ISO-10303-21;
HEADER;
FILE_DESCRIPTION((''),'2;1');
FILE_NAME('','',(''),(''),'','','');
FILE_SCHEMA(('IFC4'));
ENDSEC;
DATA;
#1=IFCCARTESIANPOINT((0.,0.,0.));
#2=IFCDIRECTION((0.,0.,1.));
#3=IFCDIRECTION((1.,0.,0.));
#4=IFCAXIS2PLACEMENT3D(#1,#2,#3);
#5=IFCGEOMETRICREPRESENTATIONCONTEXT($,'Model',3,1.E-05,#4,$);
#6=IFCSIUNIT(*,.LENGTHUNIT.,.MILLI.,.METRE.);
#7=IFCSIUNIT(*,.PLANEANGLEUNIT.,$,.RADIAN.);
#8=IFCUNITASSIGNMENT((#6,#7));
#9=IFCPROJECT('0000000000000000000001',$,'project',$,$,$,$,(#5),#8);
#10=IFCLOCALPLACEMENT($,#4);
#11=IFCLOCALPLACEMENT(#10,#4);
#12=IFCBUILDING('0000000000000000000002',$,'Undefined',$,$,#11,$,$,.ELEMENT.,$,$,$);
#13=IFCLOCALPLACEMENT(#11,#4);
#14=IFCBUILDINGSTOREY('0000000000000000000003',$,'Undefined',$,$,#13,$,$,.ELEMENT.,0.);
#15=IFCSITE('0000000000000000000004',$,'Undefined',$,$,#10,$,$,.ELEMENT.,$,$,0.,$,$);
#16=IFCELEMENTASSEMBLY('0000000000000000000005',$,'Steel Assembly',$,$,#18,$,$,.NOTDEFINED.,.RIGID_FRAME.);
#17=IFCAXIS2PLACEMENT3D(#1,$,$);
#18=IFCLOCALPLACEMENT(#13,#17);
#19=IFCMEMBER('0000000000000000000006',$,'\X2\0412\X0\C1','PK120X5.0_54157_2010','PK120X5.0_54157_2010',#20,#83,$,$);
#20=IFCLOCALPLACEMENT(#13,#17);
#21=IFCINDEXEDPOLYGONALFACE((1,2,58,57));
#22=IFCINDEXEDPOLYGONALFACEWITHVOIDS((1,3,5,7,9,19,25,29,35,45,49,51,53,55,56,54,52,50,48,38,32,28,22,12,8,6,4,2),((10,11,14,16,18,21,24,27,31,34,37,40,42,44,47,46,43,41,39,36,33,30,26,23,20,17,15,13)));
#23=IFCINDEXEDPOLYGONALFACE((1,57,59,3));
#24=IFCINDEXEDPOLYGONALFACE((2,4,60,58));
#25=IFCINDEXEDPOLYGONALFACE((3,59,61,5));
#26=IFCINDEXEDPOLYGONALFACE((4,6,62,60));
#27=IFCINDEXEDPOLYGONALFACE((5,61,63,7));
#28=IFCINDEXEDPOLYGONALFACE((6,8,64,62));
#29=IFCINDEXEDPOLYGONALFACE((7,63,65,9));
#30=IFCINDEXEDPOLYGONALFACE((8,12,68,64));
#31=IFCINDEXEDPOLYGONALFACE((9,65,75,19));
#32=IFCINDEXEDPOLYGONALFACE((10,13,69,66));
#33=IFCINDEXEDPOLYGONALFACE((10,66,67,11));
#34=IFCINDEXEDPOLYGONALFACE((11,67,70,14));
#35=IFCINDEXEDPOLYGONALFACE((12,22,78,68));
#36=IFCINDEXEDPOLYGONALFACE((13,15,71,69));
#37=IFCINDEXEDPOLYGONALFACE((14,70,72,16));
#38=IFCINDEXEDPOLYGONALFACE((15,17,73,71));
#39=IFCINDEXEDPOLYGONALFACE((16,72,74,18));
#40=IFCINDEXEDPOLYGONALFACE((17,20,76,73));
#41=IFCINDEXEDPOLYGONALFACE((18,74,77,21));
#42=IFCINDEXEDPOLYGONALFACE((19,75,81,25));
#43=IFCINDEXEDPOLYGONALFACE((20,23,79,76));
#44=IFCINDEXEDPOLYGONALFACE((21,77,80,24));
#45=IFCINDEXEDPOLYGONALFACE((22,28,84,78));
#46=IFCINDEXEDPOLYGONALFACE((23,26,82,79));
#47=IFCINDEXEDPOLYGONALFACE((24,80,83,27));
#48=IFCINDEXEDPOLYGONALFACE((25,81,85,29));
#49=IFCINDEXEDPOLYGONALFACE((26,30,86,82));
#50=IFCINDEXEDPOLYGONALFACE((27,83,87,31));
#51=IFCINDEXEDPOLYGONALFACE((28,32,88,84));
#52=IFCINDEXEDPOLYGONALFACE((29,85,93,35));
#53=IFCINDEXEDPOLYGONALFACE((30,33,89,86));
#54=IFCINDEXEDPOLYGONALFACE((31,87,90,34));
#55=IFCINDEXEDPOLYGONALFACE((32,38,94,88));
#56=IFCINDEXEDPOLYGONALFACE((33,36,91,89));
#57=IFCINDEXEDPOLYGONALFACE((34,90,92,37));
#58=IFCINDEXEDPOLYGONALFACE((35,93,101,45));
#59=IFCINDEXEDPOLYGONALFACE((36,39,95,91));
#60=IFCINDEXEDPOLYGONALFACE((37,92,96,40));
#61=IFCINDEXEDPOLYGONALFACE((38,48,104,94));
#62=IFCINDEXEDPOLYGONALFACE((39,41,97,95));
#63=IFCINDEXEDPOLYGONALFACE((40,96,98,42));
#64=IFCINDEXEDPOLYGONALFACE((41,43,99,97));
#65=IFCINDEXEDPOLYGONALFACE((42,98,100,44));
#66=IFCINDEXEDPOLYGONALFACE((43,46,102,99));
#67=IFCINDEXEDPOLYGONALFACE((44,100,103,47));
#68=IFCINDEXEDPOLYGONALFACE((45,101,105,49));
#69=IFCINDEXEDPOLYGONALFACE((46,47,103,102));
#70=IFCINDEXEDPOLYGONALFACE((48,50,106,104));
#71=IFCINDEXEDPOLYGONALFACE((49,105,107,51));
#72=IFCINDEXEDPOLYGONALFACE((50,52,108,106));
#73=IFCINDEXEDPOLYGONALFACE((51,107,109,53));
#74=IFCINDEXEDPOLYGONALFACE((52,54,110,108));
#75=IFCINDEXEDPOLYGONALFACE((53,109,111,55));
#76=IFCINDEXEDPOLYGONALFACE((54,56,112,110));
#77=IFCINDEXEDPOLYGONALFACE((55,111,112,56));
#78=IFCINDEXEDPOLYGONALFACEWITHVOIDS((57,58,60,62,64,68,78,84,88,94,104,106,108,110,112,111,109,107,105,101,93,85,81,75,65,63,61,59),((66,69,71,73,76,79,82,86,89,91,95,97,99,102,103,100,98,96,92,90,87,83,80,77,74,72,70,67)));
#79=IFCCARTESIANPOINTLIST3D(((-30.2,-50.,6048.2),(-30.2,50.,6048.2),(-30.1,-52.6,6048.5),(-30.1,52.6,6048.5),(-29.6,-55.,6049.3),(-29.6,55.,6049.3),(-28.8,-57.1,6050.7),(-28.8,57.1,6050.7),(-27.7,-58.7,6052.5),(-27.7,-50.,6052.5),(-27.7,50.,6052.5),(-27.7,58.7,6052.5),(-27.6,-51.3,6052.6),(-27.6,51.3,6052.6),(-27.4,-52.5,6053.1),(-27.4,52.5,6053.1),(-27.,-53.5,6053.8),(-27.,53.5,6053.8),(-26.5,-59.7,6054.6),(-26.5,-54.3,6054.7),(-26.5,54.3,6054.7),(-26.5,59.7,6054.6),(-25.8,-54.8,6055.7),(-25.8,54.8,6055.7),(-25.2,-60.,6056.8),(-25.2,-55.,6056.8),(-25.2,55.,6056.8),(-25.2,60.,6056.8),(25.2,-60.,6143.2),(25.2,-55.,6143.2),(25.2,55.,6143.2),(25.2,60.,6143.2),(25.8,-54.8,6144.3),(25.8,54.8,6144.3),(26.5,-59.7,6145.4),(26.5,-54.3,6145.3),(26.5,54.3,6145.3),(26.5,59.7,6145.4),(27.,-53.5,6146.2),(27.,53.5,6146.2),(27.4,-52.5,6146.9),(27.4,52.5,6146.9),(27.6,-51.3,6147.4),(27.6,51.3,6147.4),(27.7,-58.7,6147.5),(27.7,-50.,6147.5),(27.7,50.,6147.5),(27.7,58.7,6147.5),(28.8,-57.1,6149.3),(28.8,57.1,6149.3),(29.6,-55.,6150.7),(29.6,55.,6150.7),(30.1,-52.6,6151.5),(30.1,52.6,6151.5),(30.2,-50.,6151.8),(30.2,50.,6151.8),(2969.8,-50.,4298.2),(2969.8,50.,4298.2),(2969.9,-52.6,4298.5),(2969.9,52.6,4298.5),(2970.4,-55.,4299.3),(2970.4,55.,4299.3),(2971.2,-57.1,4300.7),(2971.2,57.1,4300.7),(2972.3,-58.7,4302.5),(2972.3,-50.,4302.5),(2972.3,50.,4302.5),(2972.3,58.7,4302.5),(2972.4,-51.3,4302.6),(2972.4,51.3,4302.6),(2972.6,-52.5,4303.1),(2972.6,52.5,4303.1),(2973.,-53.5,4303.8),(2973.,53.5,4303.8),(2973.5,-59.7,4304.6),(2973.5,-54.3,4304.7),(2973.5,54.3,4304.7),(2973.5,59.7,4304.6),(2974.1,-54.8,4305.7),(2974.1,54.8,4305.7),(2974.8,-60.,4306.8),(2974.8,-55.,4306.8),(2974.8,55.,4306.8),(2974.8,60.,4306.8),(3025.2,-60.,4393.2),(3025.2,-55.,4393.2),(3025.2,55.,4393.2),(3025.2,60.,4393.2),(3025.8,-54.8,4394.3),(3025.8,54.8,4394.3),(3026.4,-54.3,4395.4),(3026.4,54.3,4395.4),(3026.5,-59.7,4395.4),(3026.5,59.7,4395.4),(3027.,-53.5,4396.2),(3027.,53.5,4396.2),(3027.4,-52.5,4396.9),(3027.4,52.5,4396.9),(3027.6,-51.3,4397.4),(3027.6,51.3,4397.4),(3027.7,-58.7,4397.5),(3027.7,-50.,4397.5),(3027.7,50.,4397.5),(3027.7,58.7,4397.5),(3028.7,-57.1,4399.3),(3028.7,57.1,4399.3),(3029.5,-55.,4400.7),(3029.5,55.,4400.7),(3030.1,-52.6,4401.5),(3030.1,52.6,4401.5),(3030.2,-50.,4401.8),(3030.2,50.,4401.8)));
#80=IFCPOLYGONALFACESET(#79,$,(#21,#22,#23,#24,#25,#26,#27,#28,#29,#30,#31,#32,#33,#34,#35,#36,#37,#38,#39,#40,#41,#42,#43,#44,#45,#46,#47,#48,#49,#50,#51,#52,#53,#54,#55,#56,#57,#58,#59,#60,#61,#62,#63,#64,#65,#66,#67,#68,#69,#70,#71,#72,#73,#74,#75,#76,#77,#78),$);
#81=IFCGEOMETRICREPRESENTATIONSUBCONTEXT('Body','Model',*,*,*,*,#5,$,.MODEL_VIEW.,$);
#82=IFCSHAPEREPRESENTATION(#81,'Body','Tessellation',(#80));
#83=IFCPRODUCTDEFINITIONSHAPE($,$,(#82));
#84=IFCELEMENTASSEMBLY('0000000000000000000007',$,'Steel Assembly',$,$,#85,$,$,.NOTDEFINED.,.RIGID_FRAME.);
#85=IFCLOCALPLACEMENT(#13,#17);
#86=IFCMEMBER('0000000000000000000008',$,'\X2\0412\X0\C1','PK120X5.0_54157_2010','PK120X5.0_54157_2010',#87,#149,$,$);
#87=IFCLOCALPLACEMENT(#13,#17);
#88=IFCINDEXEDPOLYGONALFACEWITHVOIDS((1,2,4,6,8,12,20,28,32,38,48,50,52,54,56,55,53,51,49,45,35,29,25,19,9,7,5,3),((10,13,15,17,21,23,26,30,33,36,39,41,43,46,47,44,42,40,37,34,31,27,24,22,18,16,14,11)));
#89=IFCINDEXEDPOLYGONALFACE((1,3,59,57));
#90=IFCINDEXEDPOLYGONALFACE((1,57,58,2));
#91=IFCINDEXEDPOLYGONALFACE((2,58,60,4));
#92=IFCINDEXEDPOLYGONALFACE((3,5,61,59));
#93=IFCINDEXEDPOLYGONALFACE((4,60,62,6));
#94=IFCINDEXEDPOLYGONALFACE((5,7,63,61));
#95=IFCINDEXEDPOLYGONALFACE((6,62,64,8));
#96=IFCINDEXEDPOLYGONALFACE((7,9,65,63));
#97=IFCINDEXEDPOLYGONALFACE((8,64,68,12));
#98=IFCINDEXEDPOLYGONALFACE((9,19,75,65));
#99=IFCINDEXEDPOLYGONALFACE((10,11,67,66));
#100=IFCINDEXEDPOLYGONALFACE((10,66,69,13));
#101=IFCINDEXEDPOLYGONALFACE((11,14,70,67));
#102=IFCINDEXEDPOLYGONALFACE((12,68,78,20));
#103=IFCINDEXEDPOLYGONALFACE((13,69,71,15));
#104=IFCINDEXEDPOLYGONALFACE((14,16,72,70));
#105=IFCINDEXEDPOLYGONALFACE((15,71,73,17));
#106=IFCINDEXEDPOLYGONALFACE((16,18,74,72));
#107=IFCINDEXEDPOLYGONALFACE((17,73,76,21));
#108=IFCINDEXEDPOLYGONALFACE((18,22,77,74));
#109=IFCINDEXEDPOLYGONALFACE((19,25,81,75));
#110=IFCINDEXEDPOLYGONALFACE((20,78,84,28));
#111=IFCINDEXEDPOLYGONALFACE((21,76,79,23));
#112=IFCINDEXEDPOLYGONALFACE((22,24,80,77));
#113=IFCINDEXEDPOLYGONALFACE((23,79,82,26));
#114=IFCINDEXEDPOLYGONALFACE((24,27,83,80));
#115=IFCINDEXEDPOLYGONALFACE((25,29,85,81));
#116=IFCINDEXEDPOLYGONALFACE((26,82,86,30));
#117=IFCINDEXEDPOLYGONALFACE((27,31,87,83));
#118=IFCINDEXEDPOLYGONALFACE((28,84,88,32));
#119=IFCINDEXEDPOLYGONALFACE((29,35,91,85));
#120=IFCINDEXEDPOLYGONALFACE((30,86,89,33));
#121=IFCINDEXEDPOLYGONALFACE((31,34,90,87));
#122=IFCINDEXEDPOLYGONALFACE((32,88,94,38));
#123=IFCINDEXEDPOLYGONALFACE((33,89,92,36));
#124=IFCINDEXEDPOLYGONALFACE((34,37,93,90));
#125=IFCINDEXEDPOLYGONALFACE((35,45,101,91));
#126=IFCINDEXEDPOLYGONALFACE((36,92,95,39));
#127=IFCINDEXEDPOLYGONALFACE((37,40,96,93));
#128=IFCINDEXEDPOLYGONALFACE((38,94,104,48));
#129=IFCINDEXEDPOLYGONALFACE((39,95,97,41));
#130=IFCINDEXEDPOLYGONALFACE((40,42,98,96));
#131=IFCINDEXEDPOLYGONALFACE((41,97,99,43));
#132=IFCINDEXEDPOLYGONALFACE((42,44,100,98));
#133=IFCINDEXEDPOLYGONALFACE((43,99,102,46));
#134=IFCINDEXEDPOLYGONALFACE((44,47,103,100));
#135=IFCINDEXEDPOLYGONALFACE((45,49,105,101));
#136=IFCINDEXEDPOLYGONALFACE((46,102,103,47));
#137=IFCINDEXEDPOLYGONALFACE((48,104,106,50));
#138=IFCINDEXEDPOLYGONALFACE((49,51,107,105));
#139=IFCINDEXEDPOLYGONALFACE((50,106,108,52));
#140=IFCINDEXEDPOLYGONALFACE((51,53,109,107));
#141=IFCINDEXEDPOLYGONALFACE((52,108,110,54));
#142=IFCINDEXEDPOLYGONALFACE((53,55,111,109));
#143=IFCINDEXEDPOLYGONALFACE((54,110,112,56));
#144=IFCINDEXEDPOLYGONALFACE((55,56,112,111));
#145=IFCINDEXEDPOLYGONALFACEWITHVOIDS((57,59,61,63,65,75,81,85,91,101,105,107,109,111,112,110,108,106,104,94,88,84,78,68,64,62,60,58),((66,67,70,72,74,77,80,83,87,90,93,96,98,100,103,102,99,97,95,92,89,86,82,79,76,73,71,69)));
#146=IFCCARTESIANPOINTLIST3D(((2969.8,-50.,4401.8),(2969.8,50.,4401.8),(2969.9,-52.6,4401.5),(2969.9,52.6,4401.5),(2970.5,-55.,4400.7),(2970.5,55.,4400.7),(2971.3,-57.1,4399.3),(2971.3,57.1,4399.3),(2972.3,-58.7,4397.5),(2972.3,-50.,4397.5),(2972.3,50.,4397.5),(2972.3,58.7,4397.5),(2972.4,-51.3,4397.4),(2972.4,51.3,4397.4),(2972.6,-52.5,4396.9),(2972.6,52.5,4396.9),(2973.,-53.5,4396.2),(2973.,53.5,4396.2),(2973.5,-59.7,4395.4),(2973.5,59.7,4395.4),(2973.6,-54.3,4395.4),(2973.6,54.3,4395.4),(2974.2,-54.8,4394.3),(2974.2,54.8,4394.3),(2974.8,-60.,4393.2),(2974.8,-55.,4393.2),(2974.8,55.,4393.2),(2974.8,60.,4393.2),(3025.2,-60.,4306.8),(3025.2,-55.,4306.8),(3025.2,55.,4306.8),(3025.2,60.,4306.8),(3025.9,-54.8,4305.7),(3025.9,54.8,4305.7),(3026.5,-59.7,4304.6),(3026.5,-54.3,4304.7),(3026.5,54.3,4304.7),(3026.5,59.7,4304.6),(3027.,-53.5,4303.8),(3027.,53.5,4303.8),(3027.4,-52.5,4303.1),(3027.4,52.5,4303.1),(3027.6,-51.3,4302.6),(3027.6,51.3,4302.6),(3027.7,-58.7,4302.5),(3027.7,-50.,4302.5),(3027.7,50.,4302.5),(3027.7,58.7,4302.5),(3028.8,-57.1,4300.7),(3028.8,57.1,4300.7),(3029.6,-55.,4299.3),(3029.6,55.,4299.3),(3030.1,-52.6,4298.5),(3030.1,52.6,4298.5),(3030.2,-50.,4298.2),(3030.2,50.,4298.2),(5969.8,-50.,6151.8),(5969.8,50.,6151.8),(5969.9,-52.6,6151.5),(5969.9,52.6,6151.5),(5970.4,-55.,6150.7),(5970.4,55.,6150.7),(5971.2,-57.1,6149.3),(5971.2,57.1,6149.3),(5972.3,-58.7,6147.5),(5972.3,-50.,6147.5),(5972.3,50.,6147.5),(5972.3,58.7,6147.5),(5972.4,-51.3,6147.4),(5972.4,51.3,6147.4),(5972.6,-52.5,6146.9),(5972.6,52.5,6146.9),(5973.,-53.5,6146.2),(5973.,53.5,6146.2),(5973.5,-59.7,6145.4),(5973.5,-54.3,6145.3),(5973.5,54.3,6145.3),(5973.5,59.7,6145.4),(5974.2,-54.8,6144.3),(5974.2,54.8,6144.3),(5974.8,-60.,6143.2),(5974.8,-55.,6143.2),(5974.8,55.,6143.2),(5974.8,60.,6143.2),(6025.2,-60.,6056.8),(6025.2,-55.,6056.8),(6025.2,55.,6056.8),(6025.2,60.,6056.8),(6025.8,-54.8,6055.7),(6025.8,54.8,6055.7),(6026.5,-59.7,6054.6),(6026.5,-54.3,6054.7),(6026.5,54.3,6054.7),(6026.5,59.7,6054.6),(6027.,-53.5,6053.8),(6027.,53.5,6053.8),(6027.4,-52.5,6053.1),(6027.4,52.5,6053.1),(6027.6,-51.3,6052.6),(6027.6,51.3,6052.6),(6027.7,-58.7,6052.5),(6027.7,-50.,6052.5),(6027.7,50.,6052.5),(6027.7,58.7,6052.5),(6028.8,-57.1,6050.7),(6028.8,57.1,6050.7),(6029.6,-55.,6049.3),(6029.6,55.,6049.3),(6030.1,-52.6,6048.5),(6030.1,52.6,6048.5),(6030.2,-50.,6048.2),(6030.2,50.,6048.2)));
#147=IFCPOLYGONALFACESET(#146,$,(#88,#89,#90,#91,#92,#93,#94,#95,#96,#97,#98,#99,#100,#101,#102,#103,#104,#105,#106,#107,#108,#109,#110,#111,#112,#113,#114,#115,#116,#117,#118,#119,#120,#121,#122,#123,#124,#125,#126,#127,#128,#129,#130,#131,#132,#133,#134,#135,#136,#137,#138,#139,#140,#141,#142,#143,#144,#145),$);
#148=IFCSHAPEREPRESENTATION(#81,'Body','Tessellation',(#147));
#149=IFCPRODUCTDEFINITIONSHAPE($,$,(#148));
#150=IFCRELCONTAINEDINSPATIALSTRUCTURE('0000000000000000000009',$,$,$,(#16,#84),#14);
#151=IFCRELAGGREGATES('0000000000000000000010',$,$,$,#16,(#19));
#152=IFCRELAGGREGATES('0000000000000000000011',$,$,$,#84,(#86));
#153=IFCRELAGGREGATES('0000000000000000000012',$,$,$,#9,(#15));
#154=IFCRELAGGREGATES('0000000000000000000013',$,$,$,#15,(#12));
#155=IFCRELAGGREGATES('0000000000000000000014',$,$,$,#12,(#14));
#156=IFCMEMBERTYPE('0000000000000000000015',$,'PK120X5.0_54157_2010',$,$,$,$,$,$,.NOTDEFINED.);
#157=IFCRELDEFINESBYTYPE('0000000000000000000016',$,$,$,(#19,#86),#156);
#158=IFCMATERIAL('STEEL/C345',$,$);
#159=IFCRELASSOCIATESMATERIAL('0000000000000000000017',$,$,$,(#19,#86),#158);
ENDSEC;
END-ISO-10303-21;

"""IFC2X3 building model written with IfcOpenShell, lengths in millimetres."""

from ifc_helpers import new_model, si_unit, frame, origin_with_axes, origin_2d_with_axis, place, context, subcontext, project, spatial, hollow_rectangle, extrude, material, type_object, element, aggregate, save


model = new_model("IFC2X3")

# Units and contexts
model_context = context("Model", 3, precision=1e-05, world=origin_with_axes())
body_context = subcontext(model_context, "Body", "Model", "MODEL_VIEW")
ifc_project = project(units=[si_unit("LENGTHUNIT", "METRE", prefix="MILLI"), si_unit("PLANEANGLEUNIT", "RADIAN")], contexts=[model_context])

# Site, building, storey
site_placement = place(None, origin_with_axes())
site = spatial("IfcSite", under=ifc_project, at=site_placement, Name="Undefined", CompositionType="ELEMENT", RefElevation=0.0)
building_placement = place(site_placement, origin_with_axes())
building = spatial("IfcBuilding", under=site, at=building_placement, Name="Undefined", CompositionType="ELEMENT")
storey_placement = place(building_placement, origin_with_axes())
storey = spatial("IfcBuildingStorey", under=building, at=storey_placement, Name="Undefined", CompositionType="ELEMENT", Elevation=0.0)

# Shared definitions
ifc_material_1 = material(Name="STEEL/C345")

# Element assemblies, members
assembly_1_placement = place(storey_placement, origin_with_axes())
assembly_1 = element("IfcElementAssembly", 1, at=assembly_1_placement, inside=storey, Name="Steel Assembly", AssemblyPlace="NOTDEFINED", PredefinedType="RIGID_FRAME")
member_type_1 = type_object("IfcMemberType", Name="PK120X5.0_54157_2010", PredefinedType="NOTDEFINED")
member_1_placement = place(assembly_1_placement, frame((3000.0, 0.0, 4350.0), z_axis=(0.503871, 0.0, 0.863779), x_axis=(-0.863779, 0.0, 0.503871)))
member_1 = element("IfcMember", 2, at=member_1_placement, type_object=member_type_1, material=ifc_material_1, Name="ВC1", Description="PK120X5.0_54157_2010", ObjectType="PK120X5.0_54157_2010", context=body_context, shape_type="SweptSolid", body=[
    extrude(hollow_rectangle(XDim=120.0, YDim=120.0, WallThickness=5.0, InnerFilletRadius=5.0, OuterFilletRadius=10.0, at=origin_2d_with_axis()), frame((3473.1, 0.0, 0.0), z_axis=(-1.0, 0.0, 0.0), x_axis=(0.0, -1.0, 0.0)), (0.0, 0.0, 1.0), 3473.1),
])
aggregate(assembly_1, [member_1])
assembly_2_placement = place(storey_placement, origin_with_axes())
assembly_2 = element("IfcElementAssembly", 3, at=assembly_2_placement, inside=storey, Name="Steel Assembly", AssemblyPlace="NOTDEFINED", PredefinedType="RIGID_FRAME")
member_2_placement = place(assembly_2_placement, frame((3000.0, 0.0, 4350.0), z_axis=(-0.503871, 0.0, 0.863779), x_axis=(0.863779, 0.0, 0.503871)))
member_2 = element("IfcMember", 4, at=member_2_placement, type_object=member_type_1, material=ifc_material_1, Name="ВC1", Description="PK120X5.0_54157_2010", ObjectType="PK120X5.0_54157_2010", context=body_context, shape_type="SweptSolid", body=[
    extrude(hollow_rectangle(XDim=120.0, YDim=120.0, WallThickness=5.0, InnerFilletRadius=5.0, OuterFilletRadius=10.0, at=origin_2d_with_axis()), frame((3473.1, 0.0, 0.0), z_axis=(-1.0, 0.0, 0.0), x_axis=(0.0, -1.0, 0.0)), (0.0, 0.0, 1.0), 3473.1),
])
aggregate(assembly_2, [member_2])

save(model, "model.ifc")
